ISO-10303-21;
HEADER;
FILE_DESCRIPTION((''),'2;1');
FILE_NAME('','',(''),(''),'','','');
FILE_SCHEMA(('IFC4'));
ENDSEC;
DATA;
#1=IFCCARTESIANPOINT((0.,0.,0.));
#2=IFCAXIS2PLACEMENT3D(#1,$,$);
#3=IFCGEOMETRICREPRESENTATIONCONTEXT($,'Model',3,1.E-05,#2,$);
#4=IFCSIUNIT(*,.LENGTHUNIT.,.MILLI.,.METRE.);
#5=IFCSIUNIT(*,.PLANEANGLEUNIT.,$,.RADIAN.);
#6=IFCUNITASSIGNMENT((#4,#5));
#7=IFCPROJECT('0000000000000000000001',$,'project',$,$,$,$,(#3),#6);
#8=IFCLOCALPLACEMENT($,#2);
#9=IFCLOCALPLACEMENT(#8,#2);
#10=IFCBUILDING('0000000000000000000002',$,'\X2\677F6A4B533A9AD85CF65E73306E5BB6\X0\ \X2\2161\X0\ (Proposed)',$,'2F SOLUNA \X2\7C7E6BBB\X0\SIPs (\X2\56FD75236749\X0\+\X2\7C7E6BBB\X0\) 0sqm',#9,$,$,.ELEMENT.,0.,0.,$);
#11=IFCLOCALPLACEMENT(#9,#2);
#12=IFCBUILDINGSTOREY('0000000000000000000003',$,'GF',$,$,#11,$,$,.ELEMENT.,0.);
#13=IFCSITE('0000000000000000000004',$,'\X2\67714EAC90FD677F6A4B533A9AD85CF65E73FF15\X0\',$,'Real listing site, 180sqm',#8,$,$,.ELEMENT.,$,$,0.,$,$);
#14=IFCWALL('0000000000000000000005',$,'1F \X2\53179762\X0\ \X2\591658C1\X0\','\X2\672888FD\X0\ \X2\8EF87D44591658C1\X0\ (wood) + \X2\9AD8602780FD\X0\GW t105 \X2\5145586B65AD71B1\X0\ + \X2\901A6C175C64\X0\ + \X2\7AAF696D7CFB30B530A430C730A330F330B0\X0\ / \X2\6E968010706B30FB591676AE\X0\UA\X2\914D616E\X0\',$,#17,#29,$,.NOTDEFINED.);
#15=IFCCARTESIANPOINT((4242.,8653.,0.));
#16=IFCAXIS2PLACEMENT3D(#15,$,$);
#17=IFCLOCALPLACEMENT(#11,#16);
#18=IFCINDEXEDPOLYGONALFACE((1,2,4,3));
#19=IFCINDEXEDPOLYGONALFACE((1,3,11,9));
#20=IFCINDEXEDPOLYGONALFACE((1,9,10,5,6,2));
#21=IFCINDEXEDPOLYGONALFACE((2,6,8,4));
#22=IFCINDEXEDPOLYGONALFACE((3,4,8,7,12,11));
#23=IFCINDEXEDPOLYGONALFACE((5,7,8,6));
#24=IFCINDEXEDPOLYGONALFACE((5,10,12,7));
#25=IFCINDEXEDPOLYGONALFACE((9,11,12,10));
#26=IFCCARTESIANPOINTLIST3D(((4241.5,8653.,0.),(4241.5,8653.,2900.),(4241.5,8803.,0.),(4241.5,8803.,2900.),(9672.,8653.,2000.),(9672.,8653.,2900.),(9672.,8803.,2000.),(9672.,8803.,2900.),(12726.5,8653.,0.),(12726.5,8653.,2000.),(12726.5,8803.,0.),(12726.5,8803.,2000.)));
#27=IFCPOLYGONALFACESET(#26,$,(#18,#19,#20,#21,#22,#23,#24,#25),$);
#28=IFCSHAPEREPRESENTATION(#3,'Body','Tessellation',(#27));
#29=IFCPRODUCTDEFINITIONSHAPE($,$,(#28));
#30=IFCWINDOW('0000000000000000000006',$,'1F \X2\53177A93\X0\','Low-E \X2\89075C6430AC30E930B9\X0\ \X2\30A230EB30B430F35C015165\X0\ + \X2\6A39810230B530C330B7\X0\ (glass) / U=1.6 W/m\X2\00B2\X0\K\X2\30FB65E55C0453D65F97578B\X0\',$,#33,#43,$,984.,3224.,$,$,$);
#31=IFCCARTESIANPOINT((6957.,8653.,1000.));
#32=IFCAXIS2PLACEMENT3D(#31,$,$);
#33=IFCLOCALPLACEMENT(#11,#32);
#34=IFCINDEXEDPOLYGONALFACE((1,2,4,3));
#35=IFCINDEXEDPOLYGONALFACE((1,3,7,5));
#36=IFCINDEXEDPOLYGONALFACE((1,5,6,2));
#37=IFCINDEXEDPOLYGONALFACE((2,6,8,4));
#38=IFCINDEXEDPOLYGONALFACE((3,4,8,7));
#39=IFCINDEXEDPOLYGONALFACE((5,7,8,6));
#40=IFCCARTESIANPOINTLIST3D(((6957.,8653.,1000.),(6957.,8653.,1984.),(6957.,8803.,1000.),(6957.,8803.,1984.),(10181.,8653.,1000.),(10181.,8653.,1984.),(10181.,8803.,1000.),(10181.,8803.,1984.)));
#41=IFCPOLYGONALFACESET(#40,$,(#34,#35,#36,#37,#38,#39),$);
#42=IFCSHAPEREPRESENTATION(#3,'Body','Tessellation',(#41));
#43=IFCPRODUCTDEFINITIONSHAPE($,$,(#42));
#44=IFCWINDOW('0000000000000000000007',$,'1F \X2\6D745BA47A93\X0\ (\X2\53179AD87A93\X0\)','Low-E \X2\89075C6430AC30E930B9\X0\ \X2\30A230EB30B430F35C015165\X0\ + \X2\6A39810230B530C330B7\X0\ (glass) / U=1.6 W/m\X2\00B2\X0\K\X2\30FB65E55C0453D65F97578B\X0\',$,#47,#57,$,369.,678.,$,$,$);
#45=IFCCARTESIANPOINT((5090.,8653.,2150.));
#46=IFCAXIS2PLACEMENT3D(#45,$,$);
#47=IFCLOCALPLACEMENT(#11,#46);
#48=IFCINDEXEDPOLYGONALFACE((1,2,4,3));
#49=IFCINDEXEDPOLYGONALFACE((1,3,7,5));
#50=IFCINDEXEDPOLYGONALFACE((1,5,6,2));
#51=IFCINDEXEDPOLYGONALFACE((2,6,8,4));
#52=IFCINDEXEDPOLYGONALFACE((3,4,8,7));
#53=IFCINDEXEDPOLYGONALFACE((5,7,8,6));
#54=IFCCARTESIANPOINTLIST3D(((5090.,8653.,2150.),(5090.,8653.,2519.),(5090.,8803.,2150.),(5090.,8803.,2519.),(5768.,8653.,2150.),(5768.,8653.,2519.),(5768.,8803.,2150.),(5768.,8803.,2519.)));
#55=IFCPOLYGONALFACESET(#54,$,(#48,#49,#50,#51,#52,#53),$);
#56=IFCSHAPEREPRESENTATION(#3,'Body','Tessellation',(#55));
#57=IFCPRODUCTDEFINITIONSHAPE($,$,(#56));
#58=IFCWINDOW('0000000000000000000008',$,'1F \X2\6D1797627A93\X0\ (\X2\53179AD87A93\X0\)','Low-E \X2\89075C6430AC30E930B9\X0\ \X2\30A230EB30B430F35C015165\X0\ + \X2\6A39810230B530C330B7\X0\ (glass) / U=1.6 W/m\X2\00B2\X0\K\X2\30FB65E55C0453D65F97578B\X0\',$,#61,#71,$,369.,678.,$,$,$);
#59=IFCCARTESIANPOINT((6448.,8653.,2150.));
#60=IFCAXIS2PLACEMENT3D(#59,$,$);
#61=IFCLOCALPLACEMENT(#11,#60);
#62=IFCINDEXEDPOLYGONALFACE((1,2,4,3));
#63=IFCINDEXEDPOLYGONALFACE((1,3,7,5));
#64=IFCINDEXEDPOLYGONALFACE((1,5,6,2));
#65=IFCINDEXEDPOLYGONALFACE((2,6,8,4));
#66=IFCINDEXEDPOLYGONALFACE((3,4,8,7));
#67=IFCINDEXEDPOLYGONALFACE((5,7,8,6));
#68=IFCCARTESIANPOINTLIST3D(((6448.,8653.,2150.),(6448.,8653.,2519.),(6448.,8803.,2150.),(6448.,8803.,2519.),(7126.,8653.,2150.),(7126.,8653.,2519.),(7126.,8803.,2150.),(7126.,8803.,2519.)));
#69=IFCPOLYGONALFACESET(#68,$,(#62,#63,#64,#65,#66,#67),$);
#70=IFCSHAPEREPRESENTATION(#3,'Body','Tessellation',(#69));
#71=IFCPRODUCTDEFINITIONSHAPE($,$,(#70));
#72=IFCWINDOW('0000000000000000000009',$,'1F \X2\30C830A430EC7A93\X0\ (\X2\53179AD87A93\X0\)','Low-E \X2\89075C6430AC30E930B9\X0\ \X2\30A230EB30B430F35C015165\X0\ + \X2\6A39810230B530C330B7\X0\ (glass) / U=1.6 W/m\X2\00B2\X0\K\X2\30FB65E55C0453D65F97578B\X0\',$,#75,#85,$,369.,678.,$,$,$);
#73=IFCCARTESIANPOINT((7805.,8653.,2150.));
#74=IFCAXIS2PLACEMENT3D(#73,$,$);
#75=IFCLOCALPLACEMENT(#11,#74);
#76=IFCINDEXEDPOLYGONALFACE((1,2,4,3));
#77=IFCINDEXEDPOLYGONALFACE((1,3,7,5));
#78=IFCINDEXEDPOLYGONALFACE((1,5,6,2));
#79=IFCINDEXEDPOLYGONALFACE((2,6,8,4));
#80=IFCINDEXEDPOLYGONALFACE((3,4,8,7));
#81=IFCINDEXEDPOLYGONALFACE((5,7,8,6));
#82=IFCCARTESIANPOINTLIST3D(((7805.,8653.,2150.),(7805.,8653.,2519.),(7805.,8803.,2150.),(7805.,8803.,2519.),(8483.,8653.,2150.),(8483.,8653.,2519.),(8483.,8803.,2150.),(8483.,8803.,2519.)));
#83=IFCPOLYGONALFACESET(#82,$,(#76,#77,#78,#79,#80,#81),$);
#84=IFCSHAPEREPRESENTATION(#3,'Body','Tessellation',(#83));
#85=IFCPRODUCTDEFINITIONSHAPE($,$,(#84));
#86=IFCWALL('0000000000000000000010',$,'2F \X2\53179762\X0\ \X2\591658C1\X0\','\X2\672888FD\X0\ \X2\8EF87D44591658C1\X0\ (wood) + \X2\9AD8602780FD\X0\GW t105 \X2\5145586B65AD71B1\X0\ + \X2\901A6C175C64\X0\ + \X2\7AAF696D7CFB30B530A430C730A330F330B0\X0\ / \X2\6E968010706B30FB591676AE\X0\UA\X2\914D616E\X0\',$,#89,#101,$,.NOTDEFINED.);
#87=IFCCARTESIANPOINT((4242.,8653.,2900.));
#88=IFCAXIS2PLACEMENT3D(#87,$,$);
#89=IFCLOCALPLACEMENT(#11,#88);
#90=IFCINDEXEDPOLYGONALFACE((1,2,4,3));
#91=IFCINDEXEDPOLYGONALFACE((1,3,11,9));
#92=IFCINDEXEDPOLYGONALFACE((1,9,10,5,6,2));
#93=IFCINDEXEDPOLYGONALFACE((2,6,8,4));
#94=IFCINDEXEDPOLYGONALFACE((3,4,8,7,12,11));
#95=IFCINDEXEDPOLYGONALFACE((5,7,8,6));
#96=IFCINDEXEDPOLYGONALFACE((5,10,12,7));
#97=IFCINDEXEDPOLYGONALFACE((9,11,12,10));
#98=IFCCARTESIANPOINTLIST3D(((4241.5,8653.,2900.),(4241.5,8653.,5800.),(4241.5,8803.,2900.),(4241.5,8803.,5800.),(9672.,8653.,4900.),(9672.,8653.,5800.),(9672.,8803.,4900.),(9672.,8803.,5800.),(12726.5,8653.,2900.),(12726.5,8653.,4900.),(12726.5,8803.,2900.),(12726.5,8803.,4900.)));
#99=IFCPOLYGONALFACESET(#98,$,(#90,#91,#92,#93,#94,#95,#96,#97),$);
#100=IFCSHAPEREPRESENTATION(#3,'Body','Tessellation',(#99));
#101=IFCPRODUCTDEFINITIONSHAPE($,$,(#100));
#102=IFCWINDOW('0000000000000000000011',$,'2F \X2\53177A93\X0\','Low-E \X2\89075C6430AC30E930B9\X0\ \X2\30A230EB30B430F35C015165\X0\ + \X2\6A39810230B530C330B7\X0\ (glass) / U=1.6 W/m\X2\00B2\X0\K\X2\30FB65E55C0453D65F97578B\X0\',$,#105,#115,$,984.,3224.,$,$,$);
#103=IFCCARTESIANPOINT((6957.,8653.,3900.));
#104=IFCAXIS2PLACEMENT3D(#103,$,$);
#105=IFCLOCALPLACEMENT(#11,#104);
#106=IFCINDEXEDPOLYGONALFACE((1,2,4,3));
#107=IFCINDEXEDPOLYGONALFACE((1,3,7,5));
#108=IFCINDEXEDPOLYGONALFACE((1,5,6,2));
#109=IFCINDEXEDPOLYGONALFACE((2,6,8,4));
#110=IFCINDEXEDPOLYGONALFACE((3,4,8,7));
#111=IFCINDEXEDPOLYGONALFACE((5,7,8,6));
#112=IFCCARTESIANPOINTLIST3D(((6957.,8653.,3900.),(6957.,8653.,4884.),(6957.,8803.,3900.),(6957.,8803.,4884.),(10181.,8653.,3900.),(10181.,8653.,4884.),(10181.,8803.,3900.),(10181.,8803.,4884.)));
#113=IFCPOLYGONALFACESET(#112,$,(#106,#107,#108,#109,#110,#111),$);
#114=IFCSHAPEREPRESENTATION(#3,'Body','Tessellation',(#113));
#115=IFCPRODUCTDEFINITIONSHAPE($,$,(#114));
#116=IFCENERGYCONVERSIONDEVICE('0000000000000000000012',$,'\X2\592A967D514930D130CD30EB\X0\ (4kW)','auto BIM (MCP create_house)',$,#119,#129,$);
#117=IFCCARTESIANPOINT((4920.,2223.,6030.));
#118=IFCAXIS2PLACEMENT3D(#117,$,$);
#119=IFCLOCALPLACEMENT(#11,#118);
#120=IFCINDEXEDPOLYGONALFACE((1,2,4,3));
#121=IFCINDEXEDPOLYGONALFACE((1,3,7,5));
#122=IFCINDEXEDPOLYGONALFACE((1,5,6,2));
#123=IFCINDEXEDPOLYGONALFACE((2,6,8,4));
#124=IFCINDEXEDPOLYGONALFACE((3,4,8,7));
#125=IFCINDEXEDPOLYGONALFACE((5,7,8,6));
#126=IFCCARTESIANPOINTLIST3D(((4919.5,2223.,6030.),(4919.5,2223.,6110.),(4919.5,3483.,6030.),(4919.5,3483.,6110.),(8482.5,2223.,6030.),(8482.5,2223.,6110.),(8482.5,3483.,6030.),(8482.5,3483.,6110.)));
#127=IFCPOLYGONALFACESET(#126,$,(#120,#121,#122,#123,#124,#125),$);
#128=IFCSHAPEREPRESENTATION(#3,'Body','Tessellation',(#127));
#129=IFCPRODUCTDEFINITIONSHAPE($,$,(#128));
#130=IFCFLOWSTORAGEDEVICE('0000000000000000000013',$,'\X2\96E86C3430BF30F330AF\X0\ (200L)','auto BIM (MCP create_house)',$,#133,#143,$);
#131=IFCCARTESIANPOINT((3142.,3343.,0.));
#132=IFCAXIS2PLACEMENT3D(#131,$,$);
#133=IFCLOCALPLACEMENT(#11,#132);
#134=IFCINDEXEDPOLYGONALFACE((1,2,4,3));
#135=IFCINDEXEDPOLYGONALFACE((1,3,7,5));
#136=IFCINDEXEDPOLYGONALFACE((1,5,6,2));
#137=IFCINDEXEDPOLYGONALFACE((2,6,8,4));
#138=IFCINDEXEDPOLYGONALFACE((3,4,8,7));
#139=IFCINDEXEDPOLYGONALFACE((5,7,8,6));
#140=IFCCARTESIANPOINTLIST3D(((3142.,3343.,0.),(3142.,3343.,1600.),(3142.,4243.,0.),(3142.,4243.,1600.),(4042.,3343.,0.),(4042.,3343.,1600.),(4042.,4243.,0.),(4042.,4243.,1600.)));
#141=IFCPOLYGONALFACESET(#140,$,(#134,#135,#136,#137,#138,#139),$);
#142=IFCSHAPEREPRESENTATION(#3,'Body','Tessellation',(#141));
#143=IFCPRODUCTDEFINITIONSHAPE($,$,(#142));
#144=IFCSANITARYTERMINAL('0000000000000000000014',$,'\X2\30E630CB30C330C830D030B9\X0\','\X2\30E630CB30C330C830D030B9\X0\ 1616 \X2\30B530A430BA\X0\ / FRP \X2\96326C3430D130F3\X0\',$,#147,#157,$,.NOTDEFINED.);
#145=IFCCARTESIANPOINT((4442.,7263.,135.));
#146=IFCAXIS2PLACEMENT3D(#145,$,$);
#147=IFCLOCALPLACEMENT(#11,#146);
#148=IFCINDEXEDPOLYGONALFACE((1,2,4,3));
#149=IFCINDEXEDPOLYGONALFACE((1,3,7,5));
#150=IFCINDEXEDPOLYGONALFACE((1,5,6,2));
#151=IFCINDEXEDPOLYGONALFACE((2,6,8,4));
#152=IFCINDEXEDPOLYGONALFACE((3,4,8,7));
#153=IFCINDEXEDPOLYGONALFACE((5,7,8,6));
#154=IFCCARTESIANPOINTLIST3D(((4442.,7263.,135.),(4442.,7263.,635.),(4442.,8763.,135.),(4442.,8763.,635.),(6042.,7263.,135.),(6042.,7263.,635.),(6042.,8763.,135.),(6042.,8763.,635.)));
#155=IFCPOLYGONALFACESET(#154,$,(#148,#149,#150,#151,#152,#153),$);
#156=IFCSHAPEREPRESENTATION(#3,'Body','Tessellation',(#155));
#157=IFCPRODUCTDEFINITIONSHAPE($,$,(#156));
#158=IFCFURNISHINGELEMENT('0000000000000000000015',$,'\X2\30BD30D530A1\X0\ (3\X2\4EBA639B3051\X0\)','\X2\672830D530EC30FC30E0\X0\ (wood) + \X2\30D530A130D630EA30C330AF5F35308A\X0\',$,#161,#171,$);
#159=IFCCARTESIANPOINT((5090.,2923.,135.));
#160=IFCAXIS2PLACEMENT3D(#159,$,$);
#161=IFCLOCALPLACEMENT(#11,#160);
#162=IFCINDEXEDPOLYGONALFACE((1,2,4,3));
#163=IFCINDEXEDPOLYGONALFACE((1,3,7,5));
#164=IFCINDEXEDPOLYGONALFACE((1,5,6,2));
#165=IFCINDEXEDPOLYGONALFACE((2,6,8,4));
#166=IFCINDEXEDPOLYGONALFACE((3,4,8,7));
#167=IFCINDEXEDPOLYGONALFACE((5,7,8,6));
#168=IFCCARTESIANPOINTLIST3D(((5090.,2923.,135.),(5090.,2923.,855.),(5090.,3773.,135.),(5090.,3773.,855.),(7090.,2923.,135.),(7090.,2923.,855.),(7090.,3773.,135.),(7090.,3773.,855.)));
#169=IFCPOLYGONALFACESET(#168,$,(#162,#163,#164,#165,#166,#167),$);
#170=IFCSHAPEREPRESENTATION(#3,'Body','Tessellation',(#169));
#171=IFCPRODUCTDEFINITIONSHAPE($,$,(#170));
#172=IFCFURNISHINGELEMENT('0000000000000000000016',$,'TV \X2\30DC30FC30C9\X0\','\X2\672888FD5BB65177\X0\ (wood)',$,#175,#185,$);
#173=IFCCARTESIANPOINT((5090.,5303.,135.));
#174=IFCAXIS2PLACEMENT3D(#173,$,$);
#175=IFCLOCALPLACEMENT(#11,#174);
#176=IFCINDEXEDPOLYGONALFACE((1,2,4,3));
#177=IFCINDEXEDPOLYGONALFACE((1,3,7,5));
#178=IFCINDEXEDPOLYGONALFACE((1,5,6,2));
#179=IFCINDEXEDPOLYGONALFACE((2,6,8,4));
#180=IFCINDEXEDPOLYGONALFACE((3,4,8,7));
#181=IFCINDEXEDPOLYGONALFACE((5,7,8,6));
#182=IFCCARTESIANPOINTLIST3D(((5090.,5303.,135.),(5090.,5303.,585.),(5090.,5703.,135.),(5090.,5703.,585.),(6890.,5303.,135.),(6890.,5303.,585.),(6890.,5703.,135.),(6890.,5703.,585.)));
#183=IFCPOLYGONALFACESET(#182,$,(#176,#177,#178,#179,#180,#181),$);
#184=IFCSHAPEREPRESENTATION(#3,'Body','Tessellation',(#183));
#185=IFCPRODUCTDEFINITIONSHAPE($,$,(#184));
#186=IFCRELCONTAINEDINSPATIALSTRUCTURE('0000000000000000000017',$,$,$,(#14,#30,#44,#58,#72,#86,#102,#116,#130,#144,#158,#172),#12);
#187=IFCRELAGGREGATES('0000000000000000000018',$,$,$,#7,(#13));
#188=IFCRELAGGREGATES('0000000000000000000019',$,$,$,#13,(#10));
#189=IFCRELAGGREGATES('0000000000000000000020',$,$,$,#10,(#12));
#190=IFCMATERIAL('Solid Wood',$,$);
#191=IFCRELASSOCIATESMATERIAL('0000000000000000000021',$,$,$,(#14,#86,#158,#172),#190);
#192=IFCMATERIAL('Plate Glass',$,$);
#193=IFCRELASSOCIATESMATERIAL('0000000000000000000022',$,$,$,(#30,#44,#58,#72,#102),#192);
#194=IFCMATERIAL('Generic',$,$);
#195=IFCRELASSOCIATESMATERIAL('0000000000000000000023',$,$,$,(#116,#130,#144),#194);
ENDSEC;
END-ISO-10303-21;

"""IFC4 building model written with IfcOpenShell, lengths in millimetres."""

from ifc_helpers import new_model, si_unit, frame, frame_2d, origin, place, context, project, spatial, rectangle, extrude, material, element, fill, save


model = new_model("IFC4")

# Units and contexts
model_context = context("Model", 3, precision=1e-05, world=origin())
ifc_project = project(units=[si_unit("LENGTHUNIT", "METRE", prefix="MILLI"), si_unit("PLANEANGLEUNIT", "RADIAN")], contexts=[model_context])

# Site, building, storey
site_placement = place(None, origin())
site = spatial("IfcSite", under=ifc_project, at=site_placement, Name="東京都板橋区高島平５", ObjectType="Real listing site, 180sqm", CompositionType="ELEMENT", RefElevation=0.0)
building_placement = place(site_placement, origin())
building = spatial("IfcBuilding", under=site, at=building_placement, Name="板橋区高島平の家 Ⅱ (Proposed)", ObjectType="2F SOLUNA 籾殻SIPs (国産杉+籾殻) 0sqm", CompositionType="ELEMENT", ElevationOfRefHeight=0.0, ElevationOfTerrain=0.0)
storey_placement = place(building_placement, origin())
storey = spatial("IfcBuildingStorey", under=building, at=storey_placement, Name="GF", CompositionType="ELEMENT", Elevation=0.0)

# Wall, openings, windows
ifc_material_1 = material(Name="Solid Wood")
wall_1_placement = place(storey_placement, frame((4242.0, 8653.0, 0.0)))
wall_1 = element("IfcWall", 1, at=wall_1_placement, inside=storey, material=ifc_material_1, Name="1F 北面 外壁", Description="木製 軸組外壁 (wood) + 高性能GW t105 充填断熱 + 通気層 + 窯業系サイディング / 準耐火・外皮UA配慮", PredefinedType="NOTDEFINED", context=model_context, shape_type="SweptSolid", body=[
    extrude(rectangle(XDim=8485.0, YDim=150.0, at=frame_2d((4242.0, 75.0))), frame((4242.0, 8653.0, 0.0)), (0.0, 0.0, 1.0), 2900.0),
])
opening_1_placement = place(storey_placement, frame((6957.0, 8653.0, 1000.0)))
opening_1 = element("IfcOpeningElement", 2, at=opening_1_placement, cuts=wall_1, PredefinedType="NOTDEFINED", context=model_context, shape_type="SweptSolid", body=[
    extrude(rectangle(XDim=3224.0, YDim=150.0, at=frame_2d((1612.0, 75.0))), frame((6957.0, 8653.0, 1000.0)), (0.0, 0.0, 1.0), 984.0),
])
opening_2_placement = place(storey_placement, frame((5090.0, 8653.0, 2150.0)))
opening_2 = element("IfcOpeningElement", 3, at=opening_2_placement, cuts=wall_1, PredefinedType="NOTDEFINED", context=model_context, shape_type="SweptSolid", body=[
    extrude(rectangle(XDim=678.0, YDim=150.0, at=frame_2d((339.0, 75.0))), frame((5090.0, 8653.0, 2150.0)), (0.0, 0.0, 1.0), 369.0),
])
opening_3_placement = place(storey_placement, frame((6448.0, 8653.0, 2150.0)))
opening_3 = element("IfcOpeningElement", 4, at=opening_3_placement, cuts=wall_1, PredefinedType="NOTDEFINED", context=model_context, shape_type="SweptSolid", body=[
    extrude(rectangle(XDim=678.0, YDim=150.0, at=frame_2d((339.0, 75.0))), frame((6448.0, 8653.0, 2150.0)), (0.0, 0.0, 1.0), 369.0),
])
opening_4_placement = place(storey_placement, frame((7805.0, 8653.0, 2150.0)))
opening_4 = element("IfcOpeningElement", 5, at=opening_4_placement, cuts=wall_1, PredefinedType="NOTDEFINED", context=model_context, shape_type="SweptSolid", body=[
    extrude(rectangle(XDim=678.0, YDim=150.0, at=frame_2d((339.0, 75.0))), frame((7805.0, 8653.0, 2150.0)), (0.0, 0.0, 1.0), 369.0),
])
ifc_material_2 = material(Name="Plate Glass")
window_1_placement = place(storey_placement, frame((6957.0, 8653.0, 1000.0)))
window_1 = element("IfcWindow", 6, at=window_1_placement, inside=storey, material=ifc_material_2, Name="1F 北窓", Description="Low-E 複層ガラス アルゴン封入 + 樹脂サッシ (glass) / U=1.6 W/m²K・日射取得型", OverallHeight=984.0, OverallWidth=3224.0, context=model_context, shape_type="SweptSolid", body=[
    extrude(rectangle(XDim=3224.0, YDim=150.0, at=frame_2d((1612.0, 75.0))), frame((6957.0, 8653.0, 1000.0)), (0.0, 0.0, 1.0), 984.0),
])
fill(opening_1, window_1)
window_2_placement = place(storey_placement, frame((5090.0, 8653.0, 2150.0)))
window_2 = element("IfcWindow", 7, at=window_2_placement, inside=storey, material=ifc_material_2, Name="1F 浴室窓 (北高窓)", Description="Low-E 複層ガラス アルゴン封入 + 樹脂サッシ (glass) / U=1.6 W/m²K・日射取得型", OverallHeight=369.0, OverallWidth=678.0, context=model_context, shape_type="SweptSolid", body=[
    extrude(rectangle(XDim=678.0, YDim=150.0, at=frame_2d((339.0, 75.0))), frame((5090.0, 8653.0, 2150.0)), (0.0, 0.0, 1.0), 369.0),
])
fill(opening_2, window_2)
window_3_placement = place(storey_placement, frame((6448.0, 8653.0, 2150.0)))
window_3 = element("IfcWindow", 8, at=window_3_placement, inside=storey, material=ifc_material_2, Name="1F 洗面窓 (北高窓)", Description="Low-E 複層ガラス アルゴン封入 + 樹脂サッシ (glass) / U=1.6 W/m²K・日射取得型", OverallHeight=369.0, OverallWidth=678.0, context=model_context, shape_type="SweptSolid", body=[
    extrude(rectangle(XDim=678.0, YDim=150.0, at=frame_2d((339.0, 75.0))), frame((6448.0, 8653.0, 2150.0)), (0.0, 0.0, 1.0), 369.0),
])
fill(opening_3, window_3)
window_4_placement = place(storey_placement, frame((7805.0, 8653.0, 2150.0)))
window_4 = element("IfcWindow", 9, at=window_4_placement, inside=storey, material=ifc_material_2, Name="1F トイレ窓 (北高窓)", Description="Low-E 複層ガラス アルゴン封入 + 樹脂サッシ (glass) / U=1.6 W/m²K・日射取得型", OverallHeight=369.0, OverallWidth=678.0, context=model_context, shape_type="SweptSolid", body=[
    extrude(rectangle(XDim=678.0, YDim=150.0, at=frame_2d((339.0, 75.0))), frame((7805.0, 8653.0, 2150.0)), (0.0, 0.0, 1.0), 369.0),
])
fill(opening_4, window_4)

# Wall, opening, window
wall_2_placement = place(storey_placement, frame((4242.0, 8653.0, 2900.0)))
wall_2 = element("IfcWall", 10, at=wall_2_placement, inside=storey, material=ifc_material_1, Name="2F 北面 外壁", Description="木製 軸組外壁 (wood) + 高性能GW t105 充填断熱 + 通気層 + 窯業系サイディング / 準耐火・外皮UA配慮", PredefinedType="NOTDEFINED", context=model_context, shape_type="SweptSolid", body=[
    extrude(rectangle(XDim=8485.0, YDim=150.0, at=frame_2d((4242.0, 75.0))), frame((4242.0, 8653.0, 2900.0)), (0.0, 0.0, 1.0), 2900.0),
])
opening_5_placement = place(storey_placement, frame((6957.0, 8653.0, 3900.0)))
opening_5 = element("IfcOpeningElement", 11, at=opening_5_placement, cuts=wall_2, PredefinedType="NOTDEFINED", context=model_context, shape_type="SweptSolid", body=[
    extrude(rectangle(XDim=3224.0, YDim=150.0, at=frame_2d((1612.0, 75.0))), frame((6957.0, 8653.0, 3900.0)), (0.0, 0.0, 1.0), 984.0),
])
window_5_placement = place(storey_placement, frame((6957.0, 8653.0, 3900.0)))
window_5 = element("IfcWindow", 12, at=window_5_placement, inside=storey, material=ifc_material_2, Name="2F 北窓", Description="Low-E 複層ガラス アルゴン封入 + 樹脂サッシ (glass) / U=1.6 W/m²K・日射取得型", OverallHeight=984.0, OverallWidth=3224.0, context=model_context, shape_type="SweptSolid", body=[
    extrude(rectangle(XDim=3224.0, YDim=150.0, at=frame_2d((1612.0, 75.0))), frame((6957.0, 8653.0, 3900.0)), (0.0, 0.0, 1.0), 984.0),
])
fill(opening_5, window_5)

# Energy conversion device
ifc_material_3 = material(Name="Generic")
energy_conversion_device_placement = place(storey_placement, frame((4920.0, 2223.0, 6030.0)))
element("IfcEnergyConversionDevice", 13, at=energy_conversion_device_placement, inside=storey, material=ifc_material_3, Name="太陽光パネル (4kW)", Description="auto BIM (MCP create_house)", context=model_context, shape_type="SweptSolid", body=[
    extrude(rectangle(XDim=3563.0, YDim=1260.0, at=frame_2d((1781.0, 630.0))), frame((4920.0, 2223.0, 6030.0)), (0.0, 0.0, 1.0), 80.0),
])

# Flow storage device
flow_storage_device_placement = place(storey_placement, frame((3142.0, 3343.0, 0.0)))
element("IfcFlowStorageDevice", 14, at=flow_storage_device_placement, inside=storey, material=ifc_material_3, Name="雨水タンク (200L)", Description="auto BIM (MCP create_house)", context=model_context, shape_type="SweptSolid", body=[
    extrude(rectangle(XDim=900.0, YDim=900.0, at=frame_2d((450.0, 450.0))), frame((3142.0, 3343.0, 0.0)), (0.0, 0.0, 1.0), 1600.0),
])

# Sanitary terminal
sanitary_terminal_placement = place(storey_placement, frame((4442.0, 7263.0, 135.0)))
element("IfcSanitaryTerminal", 15, at=sanitary_terminal_placement, inside=storey, material=ifc_material_3, Name="ユニットバス", Description="ユニットバス 1616 サイズ / FRP 防水パン", PredefinedType="NOTDEFINED", context=model_context, shape_type="SweptSolid", body=[
    extrude(rectangle(XDim=1600.0, YDim=1500.0, at=frame_2d((800.0, 750.0))), frame((4442.0, 7263.0, 135.0)), (0.0, 0.0, 1.0), 500.0),
])

# Furnishing elements
furnishing_1_placement = place(storey_placement, frame((5090.0, 2923.0, 135.0)))
element("IfcFurnishingElement", 16, at=furnishing_1_placement, inside=storey, material=ifc_material_1, Name="ソファ (3人掛け)", Description="木フレーム (wood) + ファブリック張り", context=model_context, shape_type="SweptSolid", body=[
    extrude(rectangle(XDim=2000.0, YDim=850.0, at=frame_2d((1000.0, 425.0))), frame((5090.0, 2923.0, 135.0)), (0.0, 0.0, 1.0), 720.0),
])
furnishing_2_placement = place(storey_placement, frame((5090.0, 5303.0, 135.0)))
element("IfcFurnishingElement", 17, at=furnishing_2_placement, inside=storey, material=ifc_material_1, Name="TV ボード", Description="木製家具 (wood)", context=model_context, shape_type="SweptSolid", body=[
    extrude(rectangle(XDim=1800.0, YDim=400.0, at=frame_2d((900.0, 200.0))), frame((5090.0, 5303.0, 135.0)), (0.0, 0.0, 1.0), 450.0),
])

save(model, "model.ifc")
